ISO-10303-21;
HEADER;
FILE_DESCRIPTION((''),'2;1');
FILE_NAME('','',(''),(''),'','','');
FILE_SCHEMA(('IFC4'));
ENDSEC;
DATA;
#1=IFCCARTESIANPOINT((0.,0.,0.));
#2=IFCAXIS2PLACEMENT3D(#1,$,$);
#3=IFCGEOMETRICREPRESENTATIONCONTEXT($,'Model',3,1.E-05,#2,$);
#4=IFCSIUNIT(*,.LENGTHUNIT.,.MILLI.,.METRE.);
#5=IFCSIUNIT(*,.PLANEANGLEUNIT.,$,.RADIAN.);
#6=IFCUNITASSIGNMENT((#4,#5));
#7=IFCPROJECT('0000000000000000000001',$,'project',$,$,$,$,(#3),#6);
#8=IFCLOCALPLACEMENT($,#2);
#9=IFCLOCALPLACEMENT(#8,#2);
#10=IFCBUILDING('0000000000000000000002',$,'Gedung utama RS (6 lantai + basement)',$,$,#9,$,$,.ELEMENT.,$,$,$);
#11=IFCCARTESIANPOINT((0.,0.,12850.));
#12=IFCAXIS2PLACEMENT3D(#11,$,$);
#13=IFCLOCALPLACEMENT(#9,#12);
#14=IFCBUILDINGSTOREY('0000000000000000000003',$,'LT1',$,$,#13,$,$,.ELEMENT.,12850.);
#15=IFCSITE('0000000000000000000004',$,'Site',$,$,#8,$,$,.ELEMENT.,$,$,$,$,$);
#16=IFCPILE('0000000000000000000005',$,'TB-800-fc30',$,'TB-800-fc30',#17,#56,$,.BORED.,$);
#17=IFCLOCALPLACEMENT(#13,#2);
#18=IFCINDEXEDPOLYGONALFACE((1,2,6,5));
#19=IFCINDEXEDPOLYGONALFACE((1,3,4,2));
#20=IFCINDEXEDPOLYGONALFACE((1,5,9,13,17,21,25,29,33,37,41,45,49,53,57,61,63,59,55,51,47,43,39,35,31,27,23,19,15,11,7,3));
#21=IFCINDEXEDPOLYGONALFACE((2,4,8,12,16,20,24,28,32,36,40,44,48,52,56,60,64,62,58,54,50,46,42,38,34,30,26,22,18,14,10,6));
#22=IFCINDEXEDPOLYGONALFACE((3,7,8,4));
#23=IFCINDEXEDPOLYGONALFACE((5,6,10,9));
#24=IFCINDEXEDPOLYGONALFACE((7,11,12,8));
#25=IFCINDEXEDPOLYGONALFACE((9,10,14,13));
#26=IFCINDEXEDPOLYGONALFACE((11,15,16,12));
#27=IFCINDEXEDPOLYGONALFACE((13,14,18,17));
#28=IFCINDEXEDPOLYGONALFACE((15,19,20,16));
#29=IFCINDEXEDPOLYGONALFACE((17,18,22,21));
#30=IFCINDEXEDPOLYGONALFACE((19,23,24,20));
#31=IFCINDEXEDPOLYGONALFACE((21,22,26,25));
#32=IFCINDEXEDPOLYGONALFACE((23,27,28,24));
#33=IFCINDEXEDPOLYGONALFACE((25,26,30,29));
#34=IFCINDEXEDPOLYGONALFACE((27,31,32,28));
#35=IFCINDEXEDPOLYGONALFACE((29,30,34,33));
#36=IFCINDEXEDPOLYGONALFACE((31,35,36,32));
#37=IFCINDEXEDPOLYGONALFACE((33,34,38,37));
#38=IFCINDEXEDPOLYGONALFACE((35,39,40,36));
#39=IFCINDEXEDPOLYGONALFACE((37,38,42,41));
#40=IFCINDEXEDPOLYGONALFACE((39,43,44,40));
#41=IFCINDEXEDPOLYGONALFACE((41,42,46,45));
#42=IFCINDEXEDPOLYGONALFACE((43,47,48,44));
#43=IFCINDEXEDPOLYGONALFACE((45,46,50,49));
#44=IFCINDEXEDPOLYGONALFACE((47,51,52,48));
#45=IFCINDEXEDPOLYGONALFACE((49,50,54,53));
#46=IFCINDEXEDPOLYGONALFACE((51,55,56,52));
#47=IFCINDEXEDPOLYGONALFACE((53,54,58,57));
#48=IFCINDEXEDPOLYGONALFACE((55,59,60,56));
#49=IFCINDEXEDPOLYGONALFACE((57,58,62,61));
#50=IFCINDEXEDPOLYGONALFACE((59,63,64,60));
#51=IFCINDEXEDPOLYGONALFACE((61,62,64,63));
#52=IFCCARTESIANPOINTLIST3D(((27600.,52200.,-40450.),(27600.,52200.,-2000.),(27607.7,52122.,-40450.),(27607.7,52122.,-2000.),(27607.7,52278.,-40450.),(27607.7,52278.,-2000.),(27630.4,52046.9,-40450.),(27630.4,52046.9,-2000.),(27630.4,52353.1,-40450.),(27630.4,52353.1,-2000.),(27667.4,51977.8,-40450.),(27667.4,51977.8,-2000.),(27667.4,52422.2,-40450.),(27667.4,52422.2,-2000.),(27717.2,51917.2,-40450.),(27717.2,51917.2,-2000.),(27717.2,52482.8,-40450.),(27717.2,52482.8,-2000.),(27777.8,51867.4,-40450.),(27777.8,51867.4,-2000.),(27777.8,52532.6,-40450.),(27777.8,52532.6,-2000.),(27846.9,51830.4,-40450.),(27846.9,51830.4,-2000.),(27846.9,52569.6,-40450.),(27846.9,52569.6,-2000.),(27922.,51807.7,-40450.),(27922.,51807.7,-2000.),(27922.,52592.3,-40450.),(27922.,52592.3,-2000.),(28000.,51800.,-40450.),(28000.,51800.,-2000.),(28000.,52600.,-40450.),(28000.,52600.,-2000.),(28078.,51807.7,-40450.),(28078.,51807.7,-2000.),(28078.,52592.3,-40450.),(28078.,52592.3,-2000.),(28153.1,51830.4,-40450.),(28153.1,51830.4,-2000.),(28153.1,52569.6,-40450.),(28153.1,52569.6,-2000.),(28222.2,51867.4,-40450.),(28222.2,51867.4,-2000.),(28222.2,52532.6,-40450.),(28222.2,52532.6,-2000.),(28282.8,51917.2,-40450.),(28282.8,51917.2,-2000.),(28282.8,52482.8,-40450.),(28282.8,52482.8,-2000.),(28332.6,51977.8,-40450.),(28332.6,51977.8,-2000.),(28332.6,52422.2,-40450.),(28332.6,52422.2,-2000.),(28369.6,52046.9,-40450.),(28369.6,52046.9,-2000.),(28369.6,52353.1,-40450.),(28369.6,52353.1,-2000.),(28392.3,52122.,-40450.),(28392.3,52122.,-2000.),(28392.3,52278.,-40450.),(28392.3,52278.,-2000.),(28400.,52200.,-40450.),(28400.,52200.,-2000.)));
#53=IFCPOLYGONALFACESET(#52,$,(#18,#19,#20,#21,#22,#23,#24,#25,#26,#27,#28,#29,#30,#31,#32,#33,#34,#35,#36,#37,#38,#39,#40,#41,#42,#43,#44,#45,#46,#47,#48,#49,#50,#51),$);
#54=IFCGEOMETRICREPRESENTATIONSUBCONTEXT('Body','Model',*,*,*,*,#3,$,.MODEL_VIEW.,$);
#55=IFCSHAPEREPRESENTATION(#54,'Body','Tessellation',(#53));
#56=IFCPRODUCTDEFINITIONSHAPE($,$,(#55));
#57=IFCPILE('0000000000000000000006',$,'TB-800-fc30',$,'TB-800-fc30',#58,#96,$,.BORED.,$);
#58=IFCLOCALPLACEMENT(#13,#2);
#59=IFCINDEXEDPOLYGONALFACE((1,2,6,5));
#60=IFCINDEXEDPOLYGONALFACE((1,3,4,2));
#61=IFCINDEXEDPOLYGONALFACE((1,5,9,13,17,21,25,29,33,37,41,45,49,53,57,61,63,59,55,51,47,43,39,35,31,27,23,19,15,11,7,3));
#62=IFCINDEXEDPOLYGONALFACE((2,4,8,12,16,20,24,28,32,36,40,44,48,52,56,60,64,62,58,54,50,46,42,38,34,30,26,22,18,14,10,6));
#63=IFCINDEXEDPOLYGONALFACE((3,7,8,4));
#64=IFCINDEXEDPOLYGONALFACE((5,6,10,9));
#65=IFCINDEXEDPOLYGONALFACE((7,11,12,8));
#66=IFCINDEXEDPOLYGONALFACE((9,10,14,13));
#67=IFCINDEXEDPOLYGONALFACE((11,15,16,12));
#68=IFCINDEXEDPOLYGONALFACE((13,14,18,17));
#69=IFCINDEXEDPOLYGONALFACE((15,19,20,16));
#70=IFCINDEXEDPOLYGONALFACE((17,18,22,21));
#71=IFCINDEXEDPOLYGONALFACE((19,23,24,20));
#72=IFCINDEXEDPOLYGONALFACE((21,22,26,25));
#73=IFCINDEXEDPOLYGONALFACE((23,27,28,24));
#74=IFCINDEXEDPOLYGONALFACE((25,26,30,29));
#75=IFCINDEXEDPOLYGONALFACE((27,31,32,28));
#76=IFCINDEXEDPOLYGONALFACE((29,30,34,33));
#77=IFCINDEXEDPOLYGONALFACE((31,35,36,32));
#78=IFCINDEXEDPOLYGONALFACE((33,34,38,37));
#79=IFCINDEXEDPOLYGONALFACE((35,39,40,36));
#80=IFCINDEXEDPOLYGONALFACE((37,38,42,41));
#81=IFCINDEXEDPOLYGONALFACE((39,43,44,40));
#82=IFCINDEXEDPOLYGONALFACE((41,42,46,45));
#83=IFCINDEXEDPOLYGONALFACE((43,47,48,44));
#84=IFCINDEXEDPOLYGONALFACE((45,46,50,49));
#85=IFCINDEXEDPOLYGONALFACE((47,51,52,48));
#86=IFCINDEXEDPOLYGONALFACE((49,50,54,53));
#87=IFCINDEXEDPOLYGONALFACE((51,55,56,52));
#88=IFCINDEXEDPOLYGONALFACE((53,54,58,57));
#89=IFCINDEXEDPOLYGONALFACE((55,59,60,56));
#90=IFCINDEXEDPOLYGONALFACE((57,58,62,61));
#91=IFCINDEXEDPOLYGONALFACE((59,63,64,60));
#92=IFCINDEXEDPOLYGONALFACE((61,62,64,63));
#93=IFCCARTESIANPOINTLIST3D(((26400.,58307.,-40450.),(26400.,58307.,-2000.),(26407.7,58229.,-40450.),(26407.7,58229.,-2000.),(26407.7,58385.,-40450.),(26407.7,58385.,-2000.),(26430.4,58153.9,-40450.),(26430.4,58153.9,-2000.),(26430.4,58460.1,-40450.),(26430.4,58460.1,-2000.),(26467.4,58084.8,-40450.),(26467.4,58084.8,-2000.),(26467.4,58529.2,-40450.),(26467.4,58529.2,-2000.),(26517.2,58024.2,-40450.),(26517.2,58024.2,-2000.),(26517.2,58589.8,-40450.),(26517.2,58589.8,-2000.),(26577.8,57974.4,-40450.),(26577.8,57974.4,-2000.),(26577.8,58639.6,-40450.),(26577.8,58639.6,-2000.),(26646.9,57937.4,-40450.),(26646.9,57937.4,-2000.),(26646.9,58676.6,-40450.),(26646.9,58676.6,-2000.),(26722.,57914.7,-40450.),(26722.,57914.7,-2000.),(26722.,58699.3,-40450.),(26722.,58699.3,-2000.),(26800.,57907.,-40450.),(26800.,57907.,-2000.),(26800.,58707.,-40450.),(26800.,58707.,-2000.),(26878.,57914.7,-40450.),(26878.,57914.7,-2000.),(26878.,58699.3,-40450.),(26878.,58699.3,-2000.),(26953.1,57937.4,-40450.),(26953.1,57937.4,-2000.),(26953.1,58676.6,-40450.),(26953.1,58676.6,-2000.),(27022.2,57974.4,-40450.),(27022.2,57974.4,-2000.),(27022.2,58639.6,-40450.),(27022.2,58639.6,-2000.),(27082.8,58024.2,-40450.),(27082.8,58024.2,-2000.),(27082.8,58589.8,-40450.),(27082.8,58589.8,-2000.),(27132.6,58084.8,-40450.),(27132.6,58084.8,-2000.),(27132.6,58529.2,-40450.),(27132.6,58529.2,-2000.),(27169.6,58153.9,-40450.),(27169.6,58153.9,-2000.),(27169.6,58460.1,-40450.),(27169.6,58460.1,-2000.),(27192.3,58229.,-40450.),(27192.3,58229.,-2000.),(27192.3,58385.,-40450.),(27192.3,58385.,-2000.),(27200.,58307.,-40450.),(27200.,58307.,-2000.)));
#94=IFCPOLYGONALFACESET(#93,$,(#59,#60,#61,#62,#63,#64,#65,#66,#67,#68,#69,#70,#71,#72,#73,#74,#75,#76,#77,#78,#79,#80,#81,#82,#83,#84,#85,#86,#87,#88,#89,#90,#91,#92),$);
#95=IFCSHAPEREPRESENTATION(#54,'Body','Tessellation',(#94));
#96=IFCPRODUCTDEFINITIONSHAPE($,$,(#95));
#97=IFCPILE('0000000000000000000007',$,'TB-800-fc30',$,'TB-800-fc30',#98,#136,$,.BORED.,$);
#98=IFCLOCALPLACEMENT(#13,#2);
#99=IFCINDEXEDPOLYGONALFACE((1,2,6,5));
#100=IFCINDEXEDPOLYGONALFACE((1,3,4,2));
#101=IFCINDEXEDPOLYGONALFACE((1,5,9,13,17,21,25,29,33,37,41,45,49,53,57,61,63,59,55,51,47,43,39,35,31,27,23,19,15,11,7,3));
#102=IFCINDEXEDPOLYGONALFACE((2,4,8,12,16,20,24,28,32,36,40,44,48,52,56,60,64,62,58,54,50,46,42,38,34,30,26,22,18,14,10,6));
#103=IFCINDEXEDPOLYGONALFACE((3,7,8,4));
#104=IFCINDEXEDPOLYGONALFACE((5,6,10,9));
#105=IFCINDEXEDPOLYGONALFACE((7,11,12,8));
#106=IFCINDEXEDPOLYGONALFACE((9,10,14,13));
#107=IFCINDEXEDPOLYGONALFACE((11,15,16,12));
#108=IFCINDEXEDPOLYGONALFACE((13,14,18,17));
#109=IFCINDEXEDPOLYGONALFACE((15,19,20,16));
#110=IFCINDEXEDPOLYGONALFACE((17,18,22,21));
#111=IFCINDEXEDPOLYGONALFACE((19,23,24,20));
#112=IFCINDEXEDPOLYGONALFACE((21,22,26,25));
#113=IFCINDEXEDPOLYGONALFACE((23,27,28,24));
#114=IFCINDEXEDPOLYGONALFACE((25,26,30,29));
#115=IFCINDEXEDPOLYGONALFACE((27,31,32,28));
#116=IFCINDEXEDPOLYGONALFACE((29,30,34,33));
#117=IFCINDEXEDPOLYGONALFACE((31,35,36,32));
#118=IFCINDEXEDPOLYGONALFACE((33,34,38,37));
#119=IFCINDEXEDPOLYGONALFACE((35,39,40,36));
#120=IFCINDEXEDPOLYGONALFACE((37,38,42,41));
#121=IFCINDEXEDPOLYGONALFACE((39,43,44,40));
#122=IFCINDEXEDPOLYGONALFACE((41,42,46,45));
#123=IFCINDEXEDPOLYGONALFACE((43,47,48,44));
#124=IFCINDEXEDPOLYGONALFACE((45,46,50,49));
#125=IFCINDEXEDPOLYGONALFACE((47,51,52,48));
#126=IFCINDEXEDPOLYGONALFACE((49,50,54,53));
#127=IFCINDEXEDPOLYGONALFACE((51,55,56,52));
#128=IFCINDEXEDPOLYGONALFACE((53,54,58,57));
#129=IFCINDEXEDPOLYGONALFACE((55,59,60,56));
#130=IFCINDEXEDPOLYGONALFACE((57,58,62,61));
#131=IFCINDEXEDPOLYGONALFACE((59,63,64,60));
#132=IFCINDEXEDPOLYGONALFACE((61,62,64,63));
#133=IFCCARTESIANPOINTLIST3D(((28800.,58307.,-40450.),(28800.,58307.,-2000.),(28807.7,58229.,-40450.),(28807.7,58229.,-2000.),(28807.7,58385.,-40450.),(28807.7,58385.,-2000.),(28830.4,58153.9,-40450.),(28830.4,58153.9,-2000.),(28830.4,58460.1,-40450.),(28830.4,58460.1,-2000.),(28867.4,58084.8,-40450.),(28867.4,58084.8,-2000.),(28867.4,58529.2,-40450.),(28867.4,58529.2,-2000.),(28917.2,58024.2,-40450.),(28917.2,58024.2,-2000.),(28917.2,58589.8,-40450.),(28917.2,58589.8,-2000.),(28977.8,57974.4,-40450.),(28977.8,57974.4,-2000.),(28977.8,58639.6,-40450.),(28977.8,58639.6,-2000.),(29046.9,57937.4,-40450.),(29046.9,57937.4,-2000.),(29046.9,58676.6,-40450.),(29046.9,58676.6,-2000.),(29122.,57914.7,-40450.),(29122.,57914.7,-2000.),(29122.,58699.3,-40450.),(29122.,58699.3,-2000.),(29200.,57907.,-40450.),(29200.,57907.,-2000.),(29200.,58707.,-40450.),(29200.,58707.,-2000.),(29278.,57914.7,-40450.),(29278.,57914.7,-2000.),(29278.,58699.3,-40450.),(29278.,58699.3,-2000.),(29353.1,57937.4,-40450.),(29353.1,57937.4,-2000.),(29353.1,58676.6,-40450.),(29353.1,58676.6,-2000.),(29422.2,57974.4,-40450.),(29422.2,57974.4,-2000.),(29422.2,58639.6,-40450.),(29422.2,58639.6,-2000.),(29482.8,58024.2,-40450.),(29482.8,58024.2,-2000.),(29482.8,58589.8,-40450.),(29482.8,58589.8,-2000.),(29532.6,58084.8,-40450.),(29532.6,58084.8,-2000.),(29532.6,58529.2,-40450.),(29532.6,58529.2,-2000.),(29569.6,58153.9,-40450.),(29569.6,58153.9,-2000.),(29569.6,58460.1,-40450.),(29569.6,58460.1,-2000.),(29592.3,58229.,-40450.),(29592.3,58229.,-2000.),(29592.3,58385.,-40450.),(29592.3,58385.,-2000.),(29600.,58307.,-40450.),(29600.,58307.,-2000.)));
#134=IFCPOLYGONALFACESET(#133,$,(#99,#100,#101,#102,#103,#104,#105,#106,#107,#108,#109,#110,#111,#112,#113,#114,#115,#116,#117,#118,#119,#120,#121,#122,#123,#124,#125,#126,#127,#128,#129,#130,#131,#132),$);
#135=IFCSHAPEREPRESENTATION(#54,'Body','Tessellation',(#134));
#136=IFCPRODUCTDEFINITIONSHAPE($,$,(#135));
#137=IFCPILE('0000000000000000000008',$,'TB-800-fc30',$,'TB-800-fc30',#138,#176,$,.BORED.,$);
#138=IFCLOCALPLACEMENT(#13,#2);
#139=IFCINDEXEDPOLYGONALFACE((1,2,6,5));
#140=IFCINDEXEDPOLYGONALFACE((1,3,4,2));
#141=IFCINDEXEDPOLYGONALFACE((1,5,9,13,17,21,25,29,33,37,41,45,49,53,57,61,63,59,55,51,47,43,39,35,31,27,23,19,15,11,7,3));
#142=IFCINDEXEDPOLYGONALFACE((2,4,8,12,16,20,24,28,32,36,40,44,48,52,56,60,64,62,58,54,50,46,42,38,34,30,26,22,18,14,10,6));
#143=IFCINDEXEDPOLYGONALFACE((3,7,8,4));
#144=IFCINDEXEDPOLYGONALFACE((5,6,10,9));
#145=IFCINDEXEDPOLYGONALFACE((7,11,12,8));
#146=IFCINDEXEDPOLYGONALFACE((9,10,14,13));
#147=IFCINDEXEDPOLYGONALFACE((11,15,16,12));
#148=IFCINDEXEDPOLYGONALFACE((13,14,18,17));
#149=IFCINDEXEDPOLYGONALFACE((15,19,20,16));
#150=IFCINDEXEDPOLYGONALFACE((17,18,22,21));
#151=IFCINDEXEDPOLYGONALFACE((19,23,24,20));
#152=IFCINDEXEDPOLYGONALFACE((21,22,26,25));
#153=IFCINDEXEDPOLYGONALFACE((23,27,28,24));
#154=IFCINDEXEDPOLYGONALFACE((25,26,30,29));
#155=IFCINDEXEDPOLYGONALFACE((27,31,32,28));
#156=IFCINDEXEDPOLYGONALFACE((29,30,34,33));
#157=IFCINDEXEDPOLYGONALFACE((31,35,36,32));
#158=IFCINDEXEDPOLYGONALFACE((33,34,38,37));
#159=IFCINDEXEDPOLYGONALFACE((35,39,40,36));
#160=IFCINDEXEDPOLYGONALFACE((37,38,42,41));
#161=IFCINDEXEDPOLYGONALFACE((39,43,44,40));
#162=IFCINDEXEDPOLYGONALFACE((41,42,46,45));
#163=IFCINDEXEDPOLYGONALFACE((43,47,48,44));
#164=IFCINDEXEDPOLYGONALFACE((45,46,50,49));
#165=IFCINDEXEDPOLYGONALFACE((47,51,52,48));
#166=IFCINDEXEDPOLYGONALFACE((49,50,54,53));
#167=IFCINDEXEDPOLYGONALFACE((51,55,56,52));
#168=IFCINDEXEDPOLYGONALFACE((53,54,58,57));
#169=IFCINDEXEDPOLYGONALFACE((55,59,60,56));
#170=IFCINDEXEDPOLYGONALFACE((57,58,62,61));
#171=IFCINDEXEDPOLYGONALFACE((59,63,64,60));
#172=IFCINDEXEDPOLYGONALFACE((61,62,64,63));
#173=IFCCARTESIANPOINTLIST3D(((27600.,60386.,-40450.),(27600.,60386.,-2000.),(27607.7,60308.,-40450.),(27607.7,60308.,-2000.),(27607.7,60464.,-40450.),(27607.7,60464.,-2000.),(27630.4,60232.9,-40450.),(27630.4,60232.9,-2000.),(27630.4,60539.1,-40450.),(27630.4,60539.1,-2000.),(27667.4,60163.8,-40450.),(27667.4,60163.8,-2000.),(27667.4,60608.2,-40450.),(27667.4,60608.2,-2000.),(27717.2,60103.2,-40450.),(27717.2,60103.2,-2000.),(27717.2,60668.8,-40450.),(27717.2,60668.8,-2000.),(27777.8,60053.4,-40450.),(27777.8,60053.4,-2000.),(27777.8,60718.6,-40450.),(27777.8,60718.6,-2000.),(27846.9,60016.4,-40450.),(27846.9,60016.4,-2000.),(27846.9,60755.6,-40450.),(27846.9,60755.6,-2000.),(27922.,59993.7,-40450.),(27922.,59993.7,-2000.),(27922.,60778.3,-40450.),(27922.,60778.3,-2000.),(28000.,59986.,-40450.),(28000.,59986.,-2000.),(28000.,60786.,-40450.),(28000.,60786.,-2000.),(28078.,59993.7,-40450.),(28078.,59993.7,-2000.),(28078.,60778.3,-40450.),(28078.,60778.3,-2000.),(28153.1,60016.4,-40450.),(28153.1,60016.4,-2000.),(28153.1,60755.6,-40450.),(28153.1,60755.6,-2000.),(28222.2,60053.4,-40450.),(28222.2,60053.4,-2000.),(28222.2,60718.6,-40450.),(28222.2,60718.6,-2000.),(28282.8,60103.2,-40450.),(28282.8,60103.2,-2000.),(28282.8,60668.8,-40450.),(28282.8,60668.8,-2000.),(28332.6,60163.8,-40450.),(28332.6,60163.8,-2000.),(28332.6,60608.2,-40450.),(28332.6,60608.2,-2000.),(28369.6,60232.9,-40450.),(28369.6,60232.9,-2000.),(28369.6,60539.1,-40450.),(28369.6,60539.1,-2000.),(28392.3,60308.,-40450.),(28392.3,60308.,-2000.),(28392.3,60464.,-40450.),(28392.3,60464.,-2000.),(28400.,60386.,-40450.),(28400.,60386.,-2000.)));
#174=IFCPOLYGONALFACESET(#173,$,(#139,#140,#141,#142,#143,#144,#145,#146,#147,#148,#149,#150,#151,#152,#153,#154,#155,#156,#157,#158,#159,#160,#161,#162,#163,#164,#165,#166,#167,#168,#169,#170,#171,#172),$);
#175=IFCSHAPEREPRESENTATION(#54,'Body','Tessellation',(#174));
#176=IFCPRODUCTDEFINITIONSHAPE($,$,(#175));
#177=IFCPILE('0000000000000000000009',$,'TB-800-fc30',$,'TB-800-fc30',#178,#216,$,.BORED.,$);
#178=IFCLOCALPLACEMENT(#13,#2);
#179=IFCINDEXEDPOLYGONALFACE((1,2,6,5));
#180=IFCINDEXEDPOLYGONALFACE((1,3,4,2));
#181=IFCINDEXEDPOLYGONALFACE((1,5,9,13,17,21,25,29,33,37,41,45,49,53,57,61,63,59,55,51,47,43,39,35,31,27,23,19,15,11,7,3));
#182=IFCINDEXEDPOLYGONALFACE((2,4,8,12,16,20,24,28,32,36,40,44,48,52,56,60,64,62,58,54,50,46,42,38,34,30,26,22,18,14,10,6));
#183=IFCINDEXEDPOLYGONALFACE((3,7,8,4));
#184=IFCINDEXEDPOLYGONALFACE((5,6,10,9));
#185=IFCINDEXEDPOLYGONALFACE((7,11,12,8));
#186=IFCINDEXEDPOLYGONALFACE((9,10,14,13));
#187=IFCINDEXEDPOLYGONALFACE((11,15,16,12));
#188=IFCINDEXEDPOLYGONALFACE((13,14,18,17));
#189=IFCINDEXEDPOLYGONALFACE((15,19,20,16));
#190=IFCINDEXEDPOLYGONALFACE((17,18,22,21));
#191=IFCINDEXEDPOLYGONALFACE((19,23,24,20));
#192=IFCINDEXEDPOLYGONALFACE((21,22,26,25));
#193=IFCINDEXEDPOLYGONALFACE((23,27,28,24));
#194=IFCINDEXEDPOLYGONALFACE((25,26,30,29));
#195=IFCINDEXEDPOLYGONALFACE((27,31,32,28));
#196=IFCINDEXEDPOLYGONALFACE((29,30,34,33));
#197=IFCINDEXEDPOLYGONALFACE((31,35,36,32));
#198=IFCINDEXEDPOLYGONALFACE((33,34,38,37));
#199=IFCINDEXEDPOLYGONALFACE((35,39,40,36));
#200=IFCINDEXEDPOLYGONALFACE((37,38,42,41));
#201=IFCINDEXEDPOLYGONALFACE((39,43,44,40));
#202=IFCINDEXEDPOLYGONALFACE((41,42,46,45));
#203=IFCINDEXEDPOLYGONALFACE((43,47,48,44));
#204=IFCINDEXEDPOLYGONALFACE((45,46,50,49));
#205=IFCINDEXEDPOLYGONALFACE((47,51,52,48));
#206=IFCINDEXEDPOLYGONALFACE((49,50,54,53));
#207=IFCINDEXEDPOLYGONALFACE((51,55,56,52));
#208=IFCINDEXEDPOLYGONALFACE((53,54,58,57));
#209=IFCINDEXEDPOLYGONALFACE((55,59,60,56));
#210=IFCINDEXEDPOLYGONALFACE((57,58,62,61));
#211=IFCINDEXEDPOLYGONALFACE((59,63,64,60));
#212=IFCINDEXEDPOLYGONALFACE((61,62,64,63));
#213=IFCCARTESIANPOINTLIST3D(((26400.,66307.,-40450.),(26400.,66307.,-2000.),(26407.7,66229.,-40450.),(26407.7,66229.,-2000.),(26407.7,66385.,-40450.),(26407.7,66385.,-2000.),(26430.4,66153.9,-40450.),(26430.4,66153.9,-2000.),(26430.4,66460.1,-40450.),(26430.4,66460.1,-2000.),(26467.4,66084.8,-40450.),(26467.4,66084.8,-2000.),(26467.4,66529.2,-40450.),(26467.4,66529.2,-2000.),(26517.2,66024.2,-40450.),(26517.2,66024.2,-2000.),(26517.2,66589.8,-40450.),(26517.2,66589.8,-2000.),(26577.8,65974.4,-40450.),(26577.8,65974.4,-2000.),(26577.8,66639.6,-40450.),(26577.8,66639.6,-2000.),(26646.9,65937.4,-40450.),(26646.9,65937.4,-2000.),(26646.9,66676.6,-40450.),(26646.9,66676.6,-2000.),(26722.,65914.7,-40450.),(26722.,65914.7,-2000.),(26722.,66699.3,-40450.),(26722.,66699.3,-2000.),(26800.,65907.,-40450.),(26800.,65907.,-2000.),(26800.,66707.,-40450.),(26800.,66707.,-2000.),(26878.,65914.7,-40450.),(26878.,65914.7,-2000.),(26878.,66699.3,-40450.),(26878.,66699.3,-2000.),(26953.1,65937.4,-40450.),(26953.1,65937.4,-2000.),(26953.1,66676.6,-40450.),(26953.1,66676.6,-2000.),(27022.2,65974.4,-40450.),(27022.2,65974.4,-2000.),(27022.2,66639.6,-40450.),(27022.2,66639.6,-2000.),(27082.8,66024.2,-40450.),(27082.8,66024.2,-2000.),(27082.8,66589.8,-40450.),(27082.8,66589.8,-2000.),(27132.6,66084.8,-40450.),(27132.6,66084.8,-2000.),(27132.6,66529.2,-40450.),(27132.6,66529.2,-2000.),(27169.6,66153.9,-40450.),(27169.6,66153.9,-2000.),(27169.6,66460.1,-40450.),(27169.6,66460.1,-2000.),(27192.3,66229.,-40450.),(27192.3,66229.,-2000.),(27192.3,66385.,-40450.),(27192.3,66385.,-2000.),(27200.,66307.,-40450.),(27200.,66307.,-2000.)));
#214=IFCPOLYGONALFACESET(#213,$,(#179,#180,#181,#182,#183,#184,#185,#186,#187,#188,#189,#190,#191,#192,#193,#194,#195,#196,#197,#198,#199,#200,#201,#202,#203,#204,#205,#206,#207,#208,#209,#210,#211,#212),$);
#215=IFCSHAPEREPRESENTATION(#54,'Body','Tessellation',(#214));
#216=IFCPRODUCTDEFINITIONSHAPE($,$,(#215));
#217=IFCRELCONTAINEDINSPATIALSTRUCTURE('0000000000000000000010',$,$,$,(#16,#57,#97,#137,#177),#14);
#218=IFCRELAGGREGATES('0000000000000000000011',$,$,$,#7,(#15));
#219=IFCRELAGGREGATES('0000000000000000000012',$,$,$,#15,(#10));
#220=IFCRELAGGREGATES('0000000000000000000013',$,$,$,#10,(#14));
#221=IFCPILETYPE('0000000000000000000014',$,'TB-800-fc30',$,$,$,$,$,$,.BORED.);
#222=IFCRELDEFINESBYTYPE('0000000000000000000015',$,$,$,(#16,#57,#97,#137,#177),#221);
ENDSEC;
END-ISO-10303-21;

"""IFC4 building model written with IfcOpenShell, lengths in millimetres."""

from ifc_helpers import new_model, si_unit, frame, origin, origin_2d, place, context, subcontext, project, spatial, circle, extrude, material_profile, profile_set, profile_usage, type_object, element, save


model = new_model("IFC4")

# Units and contexts
model_context = context("Model", 3, precision=1e-05, world=origin())
body_context = subcontext(model_context, "Body", "Model", "MODEL_VIEW")
ifc_project = project(units=[si_unit("LENGTHUNIT", "METRE", prefix="MILLI"), si_unit("PLANEANGLEUNIT", "RADIAN")], contexts=[model_context])

# Site, building, storey
site_placement = place(None, origin())
site = spatial("IfcSite", under=ifc_project, at=site_placement, Name="Site", CompositionType="ELEMENT")
building_placement = place(site_placement, origin())
building = spatial("IfcBuilding", under=site, at=building_placement, Name="Gedung utama RS (6 lantai + basement)", CompositionType="ELEMENT")
storey_placement = place(building_placement, frame((0.0, 0.0, 12850.0)))
storey = spatial("IfcBuildingStorey", under=building, at=storey_placement, Name="LT1", CompositionType="ELEMENT", Elevation=12850.0)

# Piles
ifc_material_profile = material_profile(None, circle(Radius=400.0, at=origin_2d()), Name="TB-800-fc30")
ifc_profile_set = profile_set([ifc_material_profile], Name="TB-800-fc30")
ifc_profile_usage = profile_usage(ifc_profile_set, cardinal=5)
pile_type = type_object("IfcPileType", Name="TB-800-fc30", PredefinedType="BORED", material=ifc_profile_set)
for number, where, z_axis, x_axis, name in (
    (1, (28000.0, 52200.0, -40450.0), (0.0, 0.0, 1.0), (1.0, 0.0, 0.0), "TB-800-fc30"),
    (2, (26800.0, 58307.0, -40450.0), (0.0, 0.0, 1.0), (1.0, 0.0, 0.0), "TB-800-fc30"),
    (3, (29200.0, 58307.0, -40450.0), (0.0, 0.0, 1.0), (1.0, 0.0, 0.0), "TB-800-fc30"),
    (4, (28000.0, 60386.0, -40450.0), (0.0, 0.0, 1.0), (1.0, 0.0, 0.0), "TB-800-fc30"),
    (5, (26800.0, 66307.0, -40450.0), (0.0, 0.0, 1.0), (1.0, 0.0, 0.0), "TB-800-fc30"),
):
    element("IfcPile", number, at=place(storey_placement, frame(where, z_axis=z_axis, x_axis=x_axis)), inside=storey, type_object=pile_type, material=ifc_profile_usage, Name=name, ObjectType="TB-800-fc30", PredefinedType="BORED", context=body_context, shape_type="SweptSolid", body=[
        extrude(circle(Radius=400.0, at=origin_2d()), origin(), (0.0, 0.0, 1.0), 38450.0),
    ])

save(model, "model.ifc")
